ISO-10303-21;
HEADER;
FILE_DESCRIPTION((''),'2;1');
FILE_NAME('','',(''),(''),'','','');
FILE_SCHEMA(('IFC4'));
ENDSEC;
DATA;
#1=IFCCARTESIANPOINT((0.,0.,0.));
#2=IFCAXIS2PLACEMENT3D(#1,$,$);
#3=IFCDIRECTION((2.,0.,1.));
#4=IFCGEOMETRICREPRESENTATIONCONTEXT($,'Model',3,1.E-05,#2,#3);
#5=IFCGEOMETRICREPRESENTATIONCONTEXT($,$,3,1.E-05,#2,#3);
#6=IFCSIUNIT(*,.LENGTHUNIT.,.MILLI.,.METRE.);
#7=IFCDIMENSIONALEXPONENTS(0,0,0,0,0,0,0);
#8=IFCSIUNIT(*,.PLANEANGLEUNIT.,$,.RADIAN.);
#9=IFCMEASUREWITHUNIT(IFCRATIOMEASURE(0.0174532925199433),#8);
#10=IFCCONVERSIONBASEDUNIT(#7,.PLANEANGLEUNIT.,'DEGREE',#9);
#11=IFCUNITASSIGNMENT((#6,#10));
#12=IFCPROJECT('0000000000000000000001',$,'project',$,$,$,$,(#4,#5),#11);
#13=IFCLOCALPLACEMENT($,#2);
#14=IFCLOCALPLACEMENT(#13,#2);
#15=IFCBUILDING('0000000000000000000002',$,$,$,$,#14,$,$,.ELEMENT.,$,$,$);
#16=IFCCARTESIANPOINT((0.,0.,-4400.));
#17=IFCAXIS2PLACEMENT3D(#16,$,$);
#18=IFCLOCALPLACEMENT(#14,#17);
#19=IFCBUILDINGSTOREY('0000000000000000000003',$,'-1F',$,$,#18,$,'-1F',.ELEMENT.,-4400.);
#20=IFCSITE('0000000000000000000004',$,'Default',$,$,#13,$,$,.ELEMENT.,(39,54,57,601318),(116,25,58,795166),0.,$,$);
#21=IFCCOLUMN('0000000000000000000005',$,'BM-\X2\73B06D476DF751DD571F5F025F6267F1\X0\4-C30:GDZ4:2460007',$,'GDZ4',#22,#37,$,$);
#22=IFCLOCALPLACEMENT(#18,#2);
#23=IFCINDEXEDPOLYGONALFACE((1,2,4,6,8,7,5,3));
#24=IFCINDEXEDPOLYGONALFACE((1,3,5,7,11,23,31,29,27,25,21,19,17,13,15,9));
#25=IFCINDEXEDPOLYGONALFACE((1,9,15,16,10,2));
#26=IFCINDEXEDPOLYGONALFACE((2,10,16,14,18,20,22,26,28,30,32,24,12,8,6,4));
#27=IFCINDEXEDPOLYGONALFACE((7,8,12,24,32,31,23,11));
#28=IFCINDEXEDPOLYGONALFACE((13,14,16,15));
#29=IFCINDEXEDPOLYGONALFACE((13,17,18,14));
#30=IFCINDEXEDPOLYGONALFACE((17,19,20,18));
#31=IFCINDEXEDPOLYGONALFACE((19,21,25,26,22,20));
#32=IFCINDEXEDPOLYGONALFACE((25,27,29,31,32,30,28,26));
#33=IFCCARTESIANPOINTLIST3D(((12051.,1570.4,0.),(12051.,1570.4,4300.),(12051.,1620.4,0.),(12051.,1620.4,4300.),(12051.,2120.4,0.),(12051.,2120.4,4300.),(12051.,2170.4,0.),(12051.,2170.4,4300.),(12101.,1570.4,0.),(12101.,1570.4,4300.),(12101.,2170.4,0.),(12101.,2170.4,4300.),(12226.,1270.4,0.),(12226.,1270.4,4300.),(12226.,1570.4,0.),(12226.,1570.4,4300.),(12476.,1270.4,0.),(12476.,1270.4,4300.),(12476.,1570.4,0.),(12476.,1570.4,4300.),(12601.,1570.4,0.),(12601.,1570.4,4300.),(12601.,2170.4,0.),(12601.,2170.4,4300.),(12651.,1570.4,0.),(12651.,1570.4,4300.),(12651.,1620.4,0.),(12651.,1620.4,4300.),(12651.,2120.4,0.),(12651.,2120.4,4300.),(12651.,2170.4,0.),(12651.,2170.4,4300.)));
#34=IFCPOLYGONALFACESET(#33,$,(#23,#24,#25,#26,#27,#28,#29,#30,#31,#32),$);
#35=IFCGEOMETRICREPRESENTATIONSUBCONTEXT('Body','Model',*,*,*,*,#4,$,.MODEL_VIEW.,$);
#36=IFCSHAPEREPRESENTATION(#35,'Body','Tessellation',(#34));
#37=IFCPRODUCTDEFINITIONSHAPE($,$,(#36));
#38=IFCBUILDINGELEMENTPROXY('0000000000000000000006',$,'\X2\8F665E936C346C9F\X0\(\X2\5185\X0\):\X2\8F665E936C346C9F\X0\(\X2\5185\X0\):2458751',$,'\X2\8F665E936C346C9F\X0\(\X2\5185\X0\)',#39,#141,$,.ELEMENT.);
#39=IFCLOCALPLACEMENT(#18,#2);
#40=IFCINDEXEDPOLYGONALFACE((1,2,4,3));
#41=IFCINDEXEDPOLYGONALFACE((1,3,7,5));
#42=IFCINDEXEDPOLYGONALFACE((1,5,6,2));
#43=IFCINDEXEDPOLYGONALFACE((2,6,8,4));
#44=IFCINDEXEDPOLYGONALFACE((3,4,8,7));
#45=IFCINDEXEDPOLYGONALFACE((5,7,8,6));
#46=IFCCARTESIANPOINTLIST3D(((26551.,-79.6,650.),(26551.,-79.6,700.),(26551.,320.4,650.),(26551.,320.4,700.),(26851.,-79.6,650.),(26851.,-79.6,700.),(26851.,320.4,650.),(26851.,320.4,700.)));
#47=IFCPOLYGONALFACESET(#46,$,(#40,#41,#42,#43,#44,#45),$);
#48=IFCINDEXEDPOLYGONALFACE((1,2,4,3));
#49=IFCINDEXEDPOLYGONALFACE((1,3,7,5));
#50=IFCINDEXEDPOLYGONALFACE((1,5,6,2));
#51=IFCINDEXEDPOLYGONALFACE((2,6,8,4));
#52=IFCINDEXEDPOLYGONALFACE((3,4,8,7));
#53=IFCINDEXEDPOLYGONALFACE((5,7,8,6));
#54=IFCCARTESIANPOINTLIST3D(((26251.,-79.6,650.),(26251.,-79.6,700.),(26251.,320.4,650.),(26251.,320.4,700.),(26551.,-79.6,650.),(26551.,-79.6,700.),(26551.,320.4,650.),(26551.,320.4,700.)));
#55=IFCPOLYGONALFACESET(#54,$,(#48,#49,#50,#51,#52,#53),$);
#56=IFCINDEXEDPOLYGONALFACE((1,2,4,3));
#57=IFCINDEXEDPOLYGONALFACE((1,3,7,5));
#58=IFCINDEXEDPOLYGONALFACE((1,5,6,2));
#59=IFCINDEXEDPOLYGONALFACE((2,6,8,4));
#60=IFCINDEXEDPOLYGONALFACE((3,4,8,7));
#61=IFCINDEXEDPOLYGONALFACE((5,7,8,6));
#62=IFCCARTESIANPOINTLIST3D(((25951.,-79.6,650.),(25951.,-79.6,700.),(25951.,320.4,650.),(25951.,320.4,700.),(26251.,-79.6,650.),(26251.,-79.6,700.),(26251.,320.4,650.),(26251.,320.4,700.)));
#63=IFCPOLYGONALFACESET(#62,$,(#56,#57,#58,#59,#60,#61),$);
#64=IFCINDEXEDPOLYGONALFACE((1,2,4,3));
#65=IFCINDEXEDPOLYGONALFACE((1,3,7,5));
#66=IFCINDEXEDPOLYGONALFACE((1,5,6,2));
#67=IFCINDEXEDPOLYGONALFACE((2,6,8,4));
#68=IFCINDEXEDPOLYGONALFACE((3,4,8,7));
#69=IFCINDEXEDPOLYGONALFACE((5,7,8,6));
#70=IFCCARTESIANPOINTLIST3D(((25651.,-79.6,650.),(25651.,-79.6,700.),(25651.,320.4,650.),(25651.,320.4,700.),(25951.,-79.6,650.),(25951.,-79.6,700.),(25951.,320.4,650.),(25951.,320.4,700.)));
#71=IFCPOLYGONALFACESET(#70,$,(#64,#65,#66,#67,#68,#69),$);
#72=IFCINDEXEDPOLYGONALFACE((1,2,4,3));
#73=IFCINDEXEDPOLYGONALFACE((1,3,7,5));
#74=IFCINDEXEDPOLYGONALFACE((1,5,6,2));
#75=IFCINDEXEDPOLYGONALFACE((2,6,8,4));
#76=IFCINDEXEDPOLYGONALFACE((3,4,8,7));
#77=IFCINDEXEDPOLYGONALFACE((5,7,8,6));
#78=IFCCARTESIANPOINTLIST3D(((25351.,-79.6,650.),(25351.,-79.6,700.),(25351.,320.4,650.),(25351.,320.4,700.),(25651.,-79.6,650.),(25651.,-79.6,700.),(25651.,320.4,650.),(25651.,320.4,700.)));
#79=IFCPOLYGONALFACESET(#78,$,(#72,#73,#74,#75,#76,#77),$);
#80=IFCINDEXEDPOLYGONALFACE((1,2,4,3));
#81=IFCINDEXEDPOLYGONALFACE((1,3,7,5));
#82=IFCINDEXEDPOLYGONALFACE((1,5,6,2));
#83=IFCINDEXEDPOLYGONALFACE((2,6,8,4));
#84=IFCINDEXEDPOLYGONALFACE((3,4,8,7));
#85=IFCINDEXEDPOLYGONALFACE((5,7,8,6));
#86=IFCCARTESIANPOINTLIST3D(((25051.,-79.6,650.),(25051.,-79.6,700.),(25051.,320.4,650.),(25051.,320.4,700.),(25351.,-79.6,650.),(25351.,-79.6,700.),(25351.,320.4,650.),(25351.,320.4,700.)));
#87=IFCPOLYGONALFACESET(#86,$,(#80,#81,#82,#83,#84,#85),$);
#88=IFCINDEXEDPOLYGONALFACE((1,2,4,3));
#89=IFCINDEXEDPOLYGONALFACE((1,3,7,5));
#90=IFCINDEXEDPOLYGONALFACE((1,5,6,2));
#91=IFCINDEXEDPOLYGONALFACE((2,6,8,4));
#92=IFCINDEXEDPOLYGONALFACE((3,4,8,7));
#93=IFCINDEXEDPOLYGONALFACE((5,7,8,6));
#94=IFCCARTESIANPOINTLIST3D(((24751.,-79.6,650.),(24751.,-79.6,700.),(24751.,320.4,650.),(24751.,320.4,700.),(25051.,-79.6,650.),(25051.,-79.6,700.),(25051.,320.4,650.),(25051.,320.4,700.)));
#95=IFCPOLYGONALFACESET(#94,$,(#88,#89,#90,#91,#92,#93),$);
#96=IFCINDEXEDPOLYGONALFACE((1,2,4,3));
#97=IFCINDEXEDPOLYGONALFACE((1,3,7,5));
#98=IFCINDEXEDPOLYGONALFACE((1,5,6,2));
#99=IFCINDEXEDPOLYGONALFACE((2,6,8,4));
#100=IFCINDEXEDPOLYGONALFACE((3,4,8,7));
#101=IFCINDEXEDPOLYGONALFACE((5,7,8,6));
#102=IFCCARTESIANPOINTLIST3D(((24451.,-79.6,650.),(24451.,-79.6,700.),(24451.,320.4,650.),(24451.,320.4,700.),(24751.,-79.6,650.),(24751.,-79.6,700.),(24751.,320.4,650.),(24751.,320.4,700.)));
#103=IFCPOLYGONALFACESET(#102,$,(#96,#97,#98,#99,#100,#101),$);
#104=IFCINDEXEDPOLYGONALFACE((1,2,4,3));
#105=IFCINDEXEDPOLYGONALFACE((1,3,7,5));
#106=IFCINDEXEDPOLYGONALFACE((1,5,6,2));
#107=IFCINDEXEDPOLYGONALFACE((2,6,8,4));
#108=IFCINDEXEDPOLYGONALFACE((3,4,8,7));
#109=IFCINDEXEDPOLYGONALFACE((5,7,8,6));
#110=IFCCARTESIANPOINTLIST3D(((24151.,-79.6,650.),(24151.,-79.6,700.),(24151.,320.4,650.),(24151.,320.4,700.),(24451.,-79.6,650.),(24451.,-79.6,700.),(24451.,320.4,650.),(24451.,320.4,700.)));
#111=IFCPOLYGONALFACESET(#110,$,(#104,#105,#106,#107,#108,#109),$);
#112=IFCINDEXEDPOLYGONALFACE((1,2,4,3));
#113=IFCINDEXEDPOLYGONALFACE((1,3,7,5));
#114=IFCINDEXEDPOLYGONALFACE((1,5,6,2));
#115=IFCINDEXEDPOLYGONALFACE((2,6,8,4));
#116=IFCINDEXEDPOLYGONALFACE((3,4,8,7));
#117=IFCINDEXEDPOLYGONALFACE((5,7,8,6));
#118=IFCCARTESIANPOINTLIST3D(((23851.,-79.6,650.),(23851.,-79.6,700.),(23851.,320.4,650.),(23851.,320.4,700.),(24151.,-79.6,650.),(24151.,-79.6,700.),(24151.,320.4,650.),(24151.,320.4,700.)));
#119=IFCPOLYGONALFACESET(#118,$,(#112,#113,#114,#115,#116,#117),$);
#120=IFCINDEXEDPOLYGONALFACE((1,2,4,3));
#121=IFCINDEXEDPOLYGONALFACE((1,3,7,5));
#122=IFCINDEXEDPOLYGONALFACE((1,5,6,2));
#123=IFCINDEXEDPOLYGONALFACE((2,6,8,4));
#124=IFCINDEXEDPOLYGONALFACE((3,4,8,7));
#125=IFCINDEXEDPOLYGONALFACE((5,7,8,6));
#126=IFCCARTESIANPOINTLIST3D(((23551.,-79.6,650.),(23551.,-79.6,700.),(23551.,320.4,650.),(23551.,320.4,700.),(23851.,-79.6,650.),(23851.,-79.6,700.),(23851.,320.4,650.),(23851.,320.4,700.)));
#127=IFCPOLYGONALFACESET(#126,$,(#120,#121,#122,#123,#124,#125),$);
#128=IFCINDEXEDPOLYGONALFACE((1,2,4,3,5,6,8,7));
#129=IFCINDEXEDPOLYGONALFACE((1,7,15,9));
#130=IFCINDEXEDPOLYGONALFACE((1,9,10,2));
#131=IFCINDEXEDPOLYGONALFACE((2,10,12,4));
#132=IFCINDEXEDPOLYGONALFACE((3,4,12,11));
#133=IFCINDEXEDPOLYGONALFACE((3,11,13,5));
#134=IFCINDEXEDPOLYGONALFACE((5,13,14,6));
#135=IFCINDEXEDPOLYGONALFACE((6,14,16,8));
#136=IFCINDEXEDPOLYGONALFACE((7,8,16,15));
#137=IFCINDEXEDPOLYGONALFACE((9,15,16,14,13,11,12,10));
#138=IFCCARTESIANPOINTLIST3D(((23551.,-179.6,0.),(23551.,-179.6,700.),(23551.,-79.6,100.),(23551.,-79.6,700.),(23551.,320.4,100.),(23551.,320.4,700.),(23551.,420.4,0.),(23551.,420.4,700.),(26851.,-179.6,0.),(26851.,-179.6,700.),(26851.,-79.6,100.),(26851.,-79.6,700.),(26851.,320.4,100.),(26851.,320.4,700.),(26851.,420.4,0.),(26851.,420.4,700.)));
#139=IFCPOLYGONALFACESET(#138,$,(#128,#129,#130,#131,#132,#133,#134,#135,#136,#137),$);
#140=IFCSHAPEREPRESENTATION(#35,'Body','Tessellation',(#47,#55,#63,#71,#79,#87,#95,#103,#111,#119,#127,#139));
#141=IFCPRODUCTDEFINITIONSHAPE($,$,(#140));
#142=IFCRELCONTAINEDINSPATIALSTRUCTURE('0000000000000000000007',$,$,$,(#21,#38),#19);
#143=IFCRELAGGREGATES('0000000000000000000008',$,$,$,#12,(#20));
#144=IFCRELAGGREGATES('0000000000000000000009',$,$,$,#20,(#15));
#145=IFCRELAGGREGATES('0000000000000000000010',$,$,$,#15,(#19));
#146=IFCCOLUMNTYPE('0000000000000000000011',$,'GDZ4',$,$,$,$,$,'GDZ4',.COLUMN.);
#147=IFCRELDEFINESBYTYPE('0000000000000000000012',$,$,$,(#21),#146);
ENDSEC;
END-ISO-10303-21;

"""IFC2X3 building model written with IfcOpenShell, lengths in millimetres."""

from ifc_helpers import new_model, entity, si_unit, converted_unit, direction, frame, origin, origin_2d_with_axis, place, context, subcontext, project, spatial, polyline, rectangle, outline, extrude, source, transform, mapped, type_object, type_shapes, element, save


model = new_model("IFC2X3")

# Units and contexts
model_context = context("Model", 3, precision=1e-05, world=origin(), true_north=direction((2.0, 0.0, 1.0)))
context_of_model = context(None, 3, precision=1e-05, world=origin(), true_north=direction((2.0, 0.0, 1.0)))
body_context = subcontext(model_context, "Body", "Model", "MODEL_VIEW")
ifc_project = project(units=[si_unit("LENGTHUNIT", "METRE", prefix="MILLI"), converted_unit("PLANEANGLEUNIT", "DEGREE", entity("IfcRatioMeasure", 0.0174532925199433), si_unit("PLANEANGLEUNIT", "RADIAN"), dimensions=[0, 0, 0, 0, 0, 0, 0])], contexts=[model_context, context_of_model])

# Site, building, storey
site_placement = place(None, origin())
site = spatial("IfcSite", under=ifc_project, at=site_placement, Name="Default", CompositionType="ELEMENT", RefLatitude=(39, 54, 57, 601318), RefLongitude=(116, 25, 58, 795166), RefElevation=0.0)
building_placement = place(site_placement, origin())
building = spatial("IfcBuilding", under=site, at=building_placement, CompositionType="ELEMENT")
storey_placement = place(building_placement, frame((0.0, 0.0, -4400.0)))
storey = spatial("IfcBuildingStorey", under=building, at=storey_placement, Name="-1F", LongName="-1F", CompositionType="ELEMENT", Elevation=-4400.0)

# Column
column_type_1 = type_object("IfcColumnType", Name="GDZ4", ElementType="GDZ4", PredefinedType="COLUMN")
shared_shape_1 = source(origin(), body_context, "Body", "SweptSolid", [
    extrude(outline(polyline([(12651.0, 1570.4), (12651.0, 1620.4), (12651.0, 2120.4), (12651.0, 2170.4), (12601.0, 2170.4), (12101.0, 2170.4), (12051.0, 2170.4), (12051.0, 2120.4), (12051.0, 1620.4), (12051.0, 1570.4), (12101.0, 1570.4), (12226.0, 1570.4), (12226.0, 1270.4), (12476.0, 1270.4), (12476.0, 1570.4), (12601.0, 1570.4), (12651.0, 1570.4)])), origin(), (0.0, 0.0, 1.0), 4300.0),
])
type_shapes(column_type_1, [shared_shape_1])
column_1_placement = place(storey_placement, origin())
element("IfcColumn", 1, at=column_1_placement, inside=storey, type_object=column_type_1, Name="BM-现浇混凝土异形柱4-C30:GDZ4:2460007", ObjectType="GDZ4", context=body_context, shape_type="MappedRepresentation", body=[
    mapped(shared_shape_1, transform((0.0, 0.0, 0.0), scale=1.0)),
])

# Building element proxy
shared_shape_2 = source(origin(), body_context, "Body", "SweptSolid", [
    extrude(rectangle(XDim=300.0, YDim=400.0, at=origin_2d_with_axis()), frame((26701.0, 120.4, -3750.0)), (0.0, 0.0, 1.0), 50.0),
    extrude(rectangle(XDim=300.0, YDim=400.0, at=origin_2d_with_axis()), frame((26401.0, 120.4, -3750.0)), (0.0, 0.0, 1.0), 50.0),
    extrude(rectangle(XDim=300.0, YDim=400.0, at=origin_2d_with_axis()), frame((26101.0, 120.4, -3750.0)), (0.0, 0.0, 1.0), 50.0),
    extrude(rectangle(XDim=300.0, YDim=400.0, at=origin_2d_with_axis()), frame((25801.0, 120.4, -3750.0)), (0.0, 0.0, 1.0), 50.0),
    extrude(rectangle(XDim=300.0, YDim=400.0, at=origin_2d_with_axis()), frame((25501.0, 120.4, -3750.0)), (0.0, 0.0, 1.0), 50.0),
    extrude(rectangle(XDim=300.0, YDim=400.0, at=origin_2d_with_axis()), frame((25201.0, 120.4, -3750.0)), (0.0, 0.0, 1.0), 50.0),
    extrude(rectangle(XDim=300.0, YDim=400.0, at=origin_2d_with_axis()), frame((24901.0, 120.4, -3750.0)), (0.0, 0.0, 1.0), 50.0),
    extrude(rectangle(XDim=300.0, YDim=400.0, at=origin_2d_with_axis()), frame((24601.0, 120.4, -3750.0)), (0.0, 0.0, 1.0), 50.0),
    extrude(rectangle(XDim=300.0, YDim=400.0, at=origin_2d_with_axis()), frame((24301.0, 120.4, -3750.0)), (0.0, 0.0, 1.0), 50.0),
    extrude(rectangle(XDim=300.0, YDim=400.0, at=origin_2d_with_axis()), frame((24001.0, 120.4, -3750.0)), (0.0, 0.0, 1.0), 50.0),
    extrude(rectangle(XDim=300.0, YDim=400.0, at=origin_2d_with_axis()), frame((23701.0, 120.4, -3750.0)), (0.0, 0.0, 1.0), 50.0),
    extrude(outline(polyline([(-300.0, -375.0), (300.0, -375.0), (300.0, 325.0), (200.0, 325.0), (200.0, -275.0), (-200.0, -275.0), (-200.0, 325.0), (-300.0, 325.0), (-300.0, -375.0)])), frame((23551.0, 120.4, -4025.0), z_axis=(1.0, 0.0, 0.0), x_axis=(0.0, 1.0, 0.0)), (0.0, 0.0, 1.0), 3300.0),
])
proxy_placement = place(storey_placement, frame((0.0, 0.0, 4400.0)))
element("IfcBuildingElementProxy", 2, at=proxy_placement, inside=storey, Name="车库水沟(内):车库水沟(内):2458751", ObjectType="车库水沟(内)", CompositionType="ELEMENT", context=body_context, shape_type="MappedRepresentation", body=[
    mapped(shared_shape_2, transform((0.0, 0.0, 0.0), scale=1.0)),
])

save(model, "model.ifc")
